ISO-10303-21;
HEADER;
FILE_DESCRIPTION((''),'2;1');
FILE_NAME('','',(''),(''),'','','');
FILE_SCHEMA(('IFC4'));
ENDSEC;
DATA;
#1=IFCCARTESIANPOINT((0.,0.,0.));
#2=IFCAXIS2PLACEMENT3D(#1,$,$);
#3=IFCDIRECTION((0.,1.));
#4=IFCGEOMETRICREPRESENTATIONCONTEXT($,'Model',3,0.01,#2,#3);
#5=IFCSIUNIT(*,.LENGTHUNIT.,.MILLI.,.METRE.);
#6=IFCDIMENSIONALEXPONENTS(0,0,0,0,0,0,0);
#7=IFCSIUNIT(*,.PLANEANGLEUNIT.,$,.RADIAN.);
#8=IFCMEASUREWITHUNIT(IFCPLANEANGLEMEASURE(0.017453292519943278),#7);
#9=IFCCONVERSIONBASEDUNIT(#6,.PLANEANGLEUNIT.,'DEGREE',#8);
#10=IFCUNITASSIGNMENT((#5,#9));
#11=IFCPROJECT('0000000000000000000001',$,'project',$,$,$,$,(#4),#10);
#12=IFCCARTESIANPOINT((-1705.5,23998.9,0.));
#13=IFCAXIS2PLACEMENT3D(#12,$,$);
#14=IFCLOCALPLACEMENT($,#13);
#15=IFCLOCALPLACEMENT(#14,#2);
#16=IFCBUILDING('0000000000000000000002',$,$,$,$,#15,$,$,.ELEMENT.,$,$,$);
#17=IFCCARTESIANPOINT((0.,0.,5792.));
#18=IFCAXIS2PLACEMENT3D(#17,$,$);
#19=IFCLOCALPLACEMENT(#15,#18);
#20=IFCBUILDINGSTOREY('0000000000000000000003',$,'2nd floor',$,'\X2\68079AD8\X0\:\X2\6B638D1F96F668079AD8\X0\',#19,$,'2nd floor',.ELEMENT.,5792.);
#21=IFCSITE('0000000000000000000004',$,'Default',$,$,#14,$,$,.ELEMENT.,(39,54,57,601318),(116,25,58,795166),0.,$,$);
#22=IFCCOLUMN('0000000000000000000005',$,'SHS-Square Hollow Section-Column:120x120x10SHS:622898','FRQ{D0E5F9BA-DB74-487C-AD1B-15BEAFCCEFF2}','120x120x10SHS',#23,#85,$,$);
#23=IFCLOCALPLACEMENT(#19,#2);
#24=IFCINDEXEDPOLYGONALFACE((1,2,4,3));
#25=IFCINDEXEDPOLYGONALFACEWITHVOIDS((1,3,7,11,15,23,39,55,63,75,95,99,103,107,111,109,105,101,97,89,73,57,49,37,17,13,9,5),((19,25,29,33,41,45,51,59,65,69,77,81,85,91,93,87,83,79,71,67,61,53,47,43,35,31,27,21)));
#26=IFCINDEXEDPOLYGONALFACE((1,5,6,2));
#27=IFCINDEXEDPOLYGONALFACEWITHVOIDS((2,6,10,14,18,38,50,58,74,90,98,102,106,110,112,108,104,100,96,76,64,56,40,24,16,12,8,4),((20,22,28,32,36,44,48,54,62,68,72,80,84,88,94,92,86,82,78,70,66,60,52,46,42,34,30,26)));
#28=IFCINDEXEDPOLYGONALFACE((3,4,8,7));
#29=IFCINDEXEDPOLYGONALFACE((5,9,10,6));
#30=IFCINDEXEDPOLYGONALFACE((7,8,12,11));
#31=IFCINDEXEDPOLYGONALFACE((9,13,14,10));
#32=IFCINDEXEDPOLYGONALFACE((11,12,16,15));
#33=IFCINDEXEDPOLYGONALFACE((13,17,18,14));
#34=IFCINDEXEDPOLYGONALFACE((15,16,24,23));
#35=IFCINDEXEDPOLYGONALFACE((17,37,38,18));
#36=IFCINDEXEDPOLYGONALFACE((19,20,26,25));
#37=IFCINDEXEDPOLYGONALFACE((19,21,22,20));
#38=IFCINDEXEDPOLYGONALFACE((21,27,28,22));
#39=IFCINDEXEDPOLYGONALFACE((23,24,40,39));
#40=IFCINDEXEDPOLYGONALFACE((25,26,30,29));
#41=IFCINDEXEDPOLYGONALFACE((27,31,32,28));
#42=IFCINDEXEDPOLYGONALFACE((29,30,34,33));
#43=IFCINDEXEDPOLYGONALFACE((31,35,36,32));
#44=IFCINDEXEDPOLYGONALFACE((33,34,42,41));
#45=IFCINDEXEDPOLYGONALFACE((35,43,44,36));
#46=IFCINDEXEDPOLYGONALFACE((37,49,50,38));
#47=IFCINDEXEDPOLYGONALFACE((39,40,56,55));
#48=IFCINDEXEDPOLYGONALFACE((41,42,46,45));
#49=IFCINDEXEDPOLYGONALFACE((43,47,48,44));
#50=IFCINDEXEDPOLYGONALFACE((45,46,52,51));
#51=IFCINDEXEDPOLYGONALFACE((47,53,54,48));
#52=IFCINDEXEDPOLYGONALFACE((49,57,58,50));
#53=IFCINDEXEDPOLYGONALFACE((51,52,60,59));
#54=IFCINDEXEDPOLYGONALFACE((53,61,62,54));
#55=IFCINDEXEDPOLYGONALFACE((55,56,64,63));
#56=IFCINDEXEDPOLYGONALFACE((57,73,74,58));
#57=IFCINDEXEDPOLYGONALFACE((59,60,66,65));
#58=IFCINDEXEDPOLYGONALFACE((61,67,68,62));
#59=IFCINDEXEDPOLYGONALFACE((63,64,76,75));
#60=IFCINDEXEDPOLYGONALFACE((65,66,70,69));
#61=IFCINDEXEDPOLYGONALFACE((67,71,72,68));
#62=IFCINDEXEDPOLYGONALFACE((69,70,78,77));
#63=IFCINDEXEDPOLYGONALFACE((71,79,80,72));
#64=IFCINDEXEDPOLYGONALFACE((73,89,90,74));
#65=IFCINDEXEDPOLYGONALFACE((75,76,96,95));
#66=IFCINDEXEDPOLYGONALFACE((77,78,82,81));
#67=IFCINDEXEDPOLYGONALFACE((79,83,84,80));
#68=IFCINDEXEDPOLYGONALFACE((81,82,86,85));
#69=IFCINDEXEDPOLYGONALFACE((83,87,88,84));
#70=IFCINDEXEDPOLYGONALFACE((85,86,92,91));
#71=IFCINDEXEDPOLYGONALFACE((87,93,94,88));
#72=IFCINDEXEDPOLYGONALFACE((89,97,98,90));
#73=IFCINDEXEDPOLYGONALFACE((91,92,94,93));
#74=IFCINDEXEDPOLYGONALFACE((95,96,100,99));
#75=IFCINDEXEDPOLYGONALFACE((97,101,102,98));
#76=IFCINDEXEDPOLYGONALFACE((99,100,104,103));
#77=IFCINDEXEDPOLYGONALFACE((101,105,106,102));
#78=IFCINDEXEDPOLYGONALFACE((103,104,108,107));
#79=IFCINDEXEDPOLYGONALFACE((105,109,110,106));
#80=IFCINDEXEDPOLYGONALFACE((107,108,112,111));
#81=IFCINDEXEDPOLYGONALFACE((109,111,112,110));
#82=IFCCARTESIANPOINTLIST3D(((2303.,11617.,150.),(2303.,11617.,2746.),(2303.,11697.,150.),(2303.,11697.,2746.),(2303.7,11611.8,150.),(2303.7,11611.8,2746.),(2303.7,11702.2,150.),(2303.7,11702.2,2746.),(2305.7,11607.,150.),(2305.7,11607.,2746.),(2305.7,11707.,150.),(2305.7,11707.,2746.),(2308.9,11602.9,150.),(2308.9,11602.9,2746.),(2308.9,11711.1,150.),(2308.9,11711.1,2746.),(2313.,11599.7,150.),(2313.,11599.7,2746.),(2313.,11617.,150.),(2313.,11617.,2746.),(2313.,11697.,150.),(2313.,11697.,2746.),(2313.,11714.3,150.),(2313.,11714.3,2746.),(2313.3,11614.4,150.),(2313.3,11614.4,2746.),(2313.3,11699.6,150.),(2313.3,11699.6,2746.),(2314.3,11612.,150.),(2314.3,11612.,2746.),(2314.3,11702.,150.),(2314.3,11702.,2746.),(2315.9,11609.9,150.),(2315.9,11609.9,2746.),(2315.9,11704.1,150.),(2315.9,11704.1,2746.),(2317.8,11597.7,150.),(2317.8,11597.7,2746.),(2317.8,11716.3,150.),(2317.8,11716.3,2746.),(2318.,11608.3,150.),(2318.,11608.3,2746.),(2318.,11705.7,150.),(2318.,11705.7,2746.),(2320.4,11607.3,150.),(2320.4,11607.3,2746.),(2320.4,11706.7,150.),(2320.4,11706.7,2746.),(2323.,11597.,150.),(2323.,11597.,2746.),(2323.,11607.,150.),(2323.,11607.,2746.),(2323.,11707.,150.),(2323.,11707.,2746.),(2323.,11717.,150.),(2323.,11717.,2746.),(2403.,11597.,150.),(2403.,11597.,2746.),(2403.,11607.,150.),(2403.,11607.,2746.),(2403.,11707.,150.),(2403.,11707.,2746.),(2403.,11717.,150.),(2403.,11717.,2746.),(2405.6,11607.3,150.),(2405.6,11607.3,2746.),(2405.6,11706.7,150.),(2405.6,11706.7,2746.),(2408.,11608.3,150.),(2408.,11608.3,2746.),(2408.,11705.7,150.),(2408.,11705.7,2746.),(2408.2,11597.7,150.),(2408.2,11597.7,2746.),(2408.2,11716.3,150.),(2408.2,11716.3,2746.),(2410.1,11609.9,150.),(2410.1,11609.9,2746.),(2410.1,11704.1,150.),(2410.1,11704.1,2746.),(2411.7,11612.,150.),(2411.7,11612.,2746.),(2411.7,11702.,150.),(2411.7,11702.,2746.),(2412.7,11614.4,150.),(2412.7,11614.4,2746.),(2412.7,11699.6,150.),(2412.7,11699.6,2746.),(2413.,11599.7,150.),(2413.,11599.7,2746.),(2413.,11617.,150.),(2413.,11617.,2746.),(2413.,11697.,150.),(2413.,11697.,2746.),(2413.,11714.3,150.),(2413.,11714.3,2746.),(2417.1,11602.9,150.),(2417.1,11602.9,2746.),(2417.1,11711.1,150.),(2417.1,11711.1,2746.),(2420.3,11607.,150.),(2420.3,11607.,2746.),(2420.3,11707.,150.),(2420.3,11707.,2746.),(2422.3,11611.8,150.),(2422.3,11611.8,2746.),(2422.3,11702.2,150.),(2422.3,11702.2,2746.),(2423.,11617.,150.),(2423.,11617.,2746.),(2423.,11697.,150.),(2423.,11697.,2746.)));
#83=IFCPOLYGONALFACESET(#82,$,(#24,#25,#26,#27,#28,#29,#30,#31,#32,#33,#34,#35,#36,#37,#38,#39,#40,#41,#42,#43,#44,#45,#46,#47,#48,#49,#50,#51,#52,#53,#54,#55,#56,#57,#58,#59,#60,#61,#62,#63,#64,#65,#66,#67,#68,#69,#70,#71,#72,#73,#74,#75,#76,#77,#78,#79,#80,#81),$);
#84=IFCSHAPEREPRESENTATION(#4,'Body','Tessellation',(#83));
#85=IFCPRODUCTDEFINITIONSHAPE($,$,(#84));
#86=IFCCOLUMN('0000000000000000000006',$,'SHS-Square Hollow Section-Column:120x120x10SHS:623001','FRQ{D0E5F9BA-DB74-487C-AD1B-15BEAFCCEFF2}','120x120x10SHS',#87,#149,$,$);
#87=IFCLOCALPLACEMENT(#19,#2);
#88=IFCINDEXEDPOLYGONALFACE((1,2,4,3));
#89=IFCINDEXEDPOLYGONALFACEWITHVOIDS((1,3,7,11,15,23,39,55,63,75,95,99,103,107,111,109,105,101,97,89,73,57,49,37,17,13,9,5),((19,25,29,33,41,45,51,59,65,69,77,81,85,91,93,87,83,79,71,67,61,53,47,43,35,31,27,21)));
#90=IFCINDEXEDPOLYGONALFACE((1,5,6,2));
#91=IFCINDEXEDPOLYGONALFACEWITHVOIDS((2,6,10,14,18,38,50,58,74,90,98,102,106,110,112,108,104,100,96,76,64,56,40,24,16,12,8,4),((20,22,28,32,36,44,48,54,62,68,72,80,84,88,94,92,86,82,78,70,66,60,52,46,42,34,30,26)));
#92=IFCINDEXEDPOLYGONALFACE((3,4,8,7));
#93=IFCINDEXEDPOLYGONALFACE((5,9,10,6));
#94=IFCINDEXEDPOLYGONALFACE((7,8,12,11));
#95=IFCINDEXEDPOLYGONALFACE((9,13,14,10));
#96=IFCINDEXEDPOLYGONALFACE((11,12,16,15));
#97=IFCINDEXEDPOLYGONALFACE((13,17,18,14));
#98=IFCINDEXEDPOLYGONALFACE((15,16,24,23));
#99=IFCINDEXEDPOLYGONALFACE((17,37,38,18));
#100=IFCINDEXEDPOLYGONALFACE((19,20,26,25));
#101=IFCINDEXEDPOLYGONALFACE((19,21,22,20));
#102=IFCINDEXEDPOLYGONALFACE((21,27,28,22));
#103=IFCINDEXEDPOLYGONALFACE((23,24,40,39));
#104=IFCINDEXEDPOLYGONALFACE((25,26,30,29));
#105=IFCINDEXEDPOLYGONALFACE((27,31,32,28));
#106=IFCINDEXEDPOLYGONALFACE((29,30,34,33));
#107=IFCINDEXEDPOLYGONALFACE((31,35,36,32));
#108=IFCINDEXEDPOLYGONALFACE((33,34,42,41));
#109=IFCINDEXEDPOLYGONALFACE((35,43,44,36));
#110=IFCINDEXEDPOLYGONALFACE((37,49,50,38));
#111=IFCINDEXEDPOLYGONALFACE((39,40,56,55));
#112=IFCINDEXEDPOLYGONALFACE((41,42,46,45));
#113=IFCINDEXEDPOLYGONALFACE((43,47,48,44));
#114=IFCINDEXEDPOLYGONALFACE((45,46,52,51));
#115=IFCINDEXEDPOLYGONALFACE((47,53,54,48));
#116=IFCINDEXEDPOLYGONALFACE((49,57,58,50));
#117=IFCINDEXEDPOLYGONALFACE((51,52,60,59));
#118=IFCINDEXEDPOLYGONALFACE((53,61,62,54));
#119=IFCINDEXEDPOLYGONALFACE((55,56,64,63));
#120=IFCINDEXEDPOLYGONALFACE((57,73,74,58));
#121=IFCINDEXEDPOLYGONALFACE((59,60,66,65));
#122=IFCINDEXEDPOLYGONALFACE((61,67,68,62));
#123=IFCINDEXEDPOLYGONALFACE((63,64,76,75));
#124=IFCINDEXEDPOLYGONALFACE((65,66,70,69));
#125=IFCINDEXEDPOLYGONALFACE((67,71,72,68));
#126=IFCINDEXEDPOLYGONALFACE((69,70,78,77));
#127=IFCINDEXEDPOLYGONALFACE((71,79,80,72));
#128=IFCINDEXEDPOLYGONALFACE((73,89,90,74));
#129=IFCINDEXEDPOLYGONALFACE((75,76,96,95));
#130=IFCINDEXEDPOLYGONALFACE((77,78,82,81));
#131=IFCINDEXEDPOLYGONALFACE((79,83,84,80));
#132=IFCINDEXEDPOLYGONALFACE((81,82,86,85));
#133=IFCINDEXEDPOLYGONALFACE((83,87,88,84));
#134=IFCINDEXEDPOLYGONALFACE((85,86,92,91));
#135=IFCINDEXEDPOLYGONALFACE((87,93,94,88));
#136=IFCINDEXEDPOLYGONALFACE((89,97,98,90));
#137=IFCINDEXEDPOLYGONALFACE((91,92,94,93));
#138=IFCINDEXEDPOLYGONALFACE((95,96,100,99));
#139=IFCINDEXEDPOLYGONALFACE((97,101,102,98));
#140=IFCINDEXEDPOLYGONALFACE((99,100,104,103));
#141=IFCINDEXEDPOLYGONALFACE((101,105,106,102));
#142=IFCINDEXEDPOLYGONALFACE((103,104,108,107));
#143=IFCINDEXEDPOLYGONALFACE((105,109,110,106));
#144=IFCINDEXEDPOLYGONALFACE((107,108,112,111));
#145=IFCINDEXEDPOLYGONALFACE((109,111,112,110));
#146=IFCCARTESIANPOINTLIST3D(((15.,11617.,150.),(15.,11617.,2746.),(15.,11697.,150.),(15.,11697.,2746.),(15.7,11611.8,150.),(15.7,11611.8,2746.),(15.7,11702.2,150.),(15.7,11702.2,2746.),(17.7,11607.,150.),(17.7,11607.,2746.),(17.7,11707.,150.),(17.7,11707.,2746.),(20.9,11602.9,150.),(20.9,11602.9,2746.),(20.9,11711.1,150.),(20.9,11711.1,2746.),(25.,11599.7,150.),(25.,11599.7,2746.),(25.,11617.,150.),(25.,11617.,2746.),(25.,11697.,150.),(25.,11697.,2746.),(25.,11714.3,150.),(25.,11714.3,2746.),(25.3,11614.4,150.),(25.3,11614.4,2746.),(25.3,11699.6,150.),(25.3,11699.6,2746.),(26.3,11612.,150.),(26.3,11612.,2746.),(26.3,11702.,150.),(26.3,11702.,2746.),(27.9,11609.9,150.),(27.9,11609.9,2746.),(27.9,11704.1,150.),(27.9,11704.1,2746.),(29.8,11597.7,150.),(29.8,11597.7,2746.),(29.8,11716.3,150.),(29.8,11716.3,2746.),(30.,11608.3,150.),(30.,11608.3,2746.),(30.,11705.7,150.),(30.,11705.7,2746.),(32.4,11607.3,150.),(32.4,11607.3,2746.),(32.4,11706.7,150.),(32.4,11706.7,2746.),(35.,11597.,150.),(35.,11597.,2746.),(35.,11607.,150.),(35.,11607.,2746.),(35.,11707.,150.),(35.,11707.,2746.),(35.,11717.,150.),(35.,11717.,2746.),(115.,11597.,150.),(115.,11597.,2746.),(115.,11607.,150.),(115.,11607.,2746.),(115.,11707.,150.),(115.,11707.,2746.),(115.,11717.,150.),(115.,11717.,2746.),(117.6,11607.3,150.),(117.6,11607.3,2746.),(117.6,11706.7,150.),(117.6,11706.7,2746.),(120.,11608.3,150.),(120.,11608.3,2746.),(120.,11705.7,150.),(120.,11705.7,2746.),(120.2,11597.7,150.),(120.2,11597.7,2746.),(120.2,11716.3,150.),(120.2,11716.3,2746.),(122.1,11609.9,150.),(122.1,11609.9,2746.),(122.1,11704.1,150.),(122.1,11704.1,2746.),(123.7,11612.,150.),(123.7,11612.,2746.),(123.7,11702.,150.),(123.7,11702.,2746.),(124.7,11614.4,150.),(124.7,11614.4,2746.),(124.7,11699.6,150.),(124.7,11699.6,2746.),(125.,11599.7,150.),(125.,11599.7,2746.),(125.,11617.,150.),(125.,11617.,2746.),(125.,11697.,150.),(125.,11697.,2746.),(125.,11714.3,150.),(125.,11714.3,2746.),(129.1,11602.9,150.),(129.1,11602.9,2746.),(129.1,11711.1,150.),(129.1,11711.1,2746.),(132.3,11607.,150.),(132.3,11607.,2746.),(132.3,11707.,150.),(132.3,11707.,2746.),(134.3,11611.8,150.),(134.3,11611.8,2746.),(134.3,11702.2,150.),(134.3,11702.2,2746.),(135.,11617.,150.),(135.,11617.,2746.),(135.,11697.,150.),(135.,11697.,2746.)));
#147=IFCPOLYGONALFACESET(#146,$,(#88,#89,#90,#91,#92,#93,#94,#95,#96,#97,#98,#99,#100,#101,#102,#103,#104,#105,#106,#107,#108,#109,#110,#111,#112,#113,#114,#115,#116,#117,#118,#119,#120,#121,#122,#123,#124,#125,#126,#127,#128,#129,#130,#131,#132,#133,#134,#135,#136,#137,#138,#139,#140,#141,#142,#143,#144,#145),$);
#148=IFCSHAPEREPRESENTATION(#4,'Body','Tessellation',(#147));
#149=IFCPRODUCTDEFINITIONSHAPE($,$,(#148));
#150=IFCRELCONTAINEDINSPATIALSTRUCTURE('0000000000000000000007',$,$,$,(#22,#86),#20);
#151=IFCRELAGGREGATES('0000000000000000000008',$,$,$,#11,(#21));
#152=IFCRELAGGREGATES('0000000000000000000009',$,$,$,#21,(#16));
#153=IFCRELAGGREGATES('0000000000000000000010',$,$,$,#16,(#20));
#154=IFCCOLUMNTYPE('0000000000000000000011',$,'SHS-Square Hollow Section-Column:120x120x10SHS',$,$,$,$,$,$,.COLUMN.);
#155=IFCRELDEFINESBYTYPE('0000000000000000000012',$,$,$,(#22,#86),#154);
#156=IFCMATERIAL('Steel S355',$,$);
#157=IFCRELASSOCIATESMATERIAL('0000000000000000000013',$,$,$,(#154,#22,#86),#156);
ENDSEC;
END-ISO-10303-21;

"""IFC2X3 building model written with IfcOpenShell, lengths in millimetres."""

from ifc_helpers import new_model, entity, si_unit, converted_unit, direction, frame, origin, origin_2d, place, context, project, spatial, hollow_rectangle, extrude, clip, halfspace, material, type_object, element, save


model = new_model("IFC2X3")

# Units and contexts
model_context = context("Model", 3, precision=0.01, world=origin(), true_north=direction((0.0, 1.0)))
ifc_project = project(units=[si_unit("LENGTHUNIT", "METRE", prefix="MILLI"), converted_unit("PLANEANGLEUNIT", "DEGREE", entity("IfcPlaneAngleMeasure", 0.017453292519943278), si_unit("PLANEANGLEUNIT", "RADIAN"), dimensions=[0, 0, 0, 0, 0, 0, 0])], contexts=[model_context])

# Site, building, storey
site_placement = place(None, frame((-1705.5, 23998.9, 0.0)))
site = spatial("IfcSite", under=ifc_project, at=site_placement, Name="Default", CompositionType="ELEMENT", RefLatitude=(39, 54, 57, 601318), RefLongitude=(116, 25, 58, 795166), RefElevation=0.0)
building_placement = place(site_placement, origin())
building = spatial("IfcBuilding", under=site, at=building_placement, CompositionType="ELEMENT")
storey_placement = place(building_placement, frame((0.0, 0.0, 5792.0)))
storey = spatial("IfcBuildingStorey", under=building, at=storey_placement, Name="2nd floor", ObjectType="标高:正负零标高", LongName="2nd floor", CompositionType="ELEMENT", Elevation=5792.0)

# Shared definitions
ifc_material_1 = material(Name="Steel S355")

# Columns
column_type_1 = type_object("IfcColumnType", Name="SHS-Square Hollow Section-Column:120x120x10SHS", PredefinedType="COLUMN", material=ifc_material_1)
column_1_placement = place(storey_placement, frame((2363.0, 11657.0, 2830.9), z_axis=(0.0, 0.0, 1.0), x_axis=(0.0, -1.0, 0.0)))
element("IfcColumn", 1, at=column_1_placement, inside=storey, type_object=column_type_1, material=ifc_material_1, Name="SHS-Square Hollow Section-Column:120x120x10SHS:622898", Description="FRQ{D0E5F9BA-DB74-487C-AD1B-15BEAFCCEFF2}", ObjectType="120x120x10SHS", context=model_context, shape_type="Clipping", body=[
    clip(clip(extrude(hollow_rectangle(XDim=120.0, YDim=120.0, WallThickness=10.0, InnerFilletRadius=10.0, OuterFilletRadius=20.0, at=origin_2d()), origin(), (0.0, 0.0, -1.0), 2765.7), halfspace(frame((11657.0, -2363.0, -84.9), z_axis=(0.0, 0.0, -1.0), x_axis=(0.0, -1.0, 0.0)), True)), halfspace(frame((11657.0, -2363.0, -2680.9), z_axis=(0.0, 0.0, 1.0), x_axis=(0.0, 1.0, 0.0)), True)),
])
column_2_placement = place(storey_placement, frame((75.0, 11657.0, 2830.9), z_axis=(0.0, 0.0, 1.0), x_axis=(0.0, -1.0, 0.0)))
element("IfcColumn", 2, at=column_2_placement, inside=storey, type_object=column_type_1, material=ifc_material_1, Name="SHS-Square Hollow Section-Column:120x120x10SHS:623001", Description="FRQ{D0E5F9BA-DB74-487C-AD1B-15BEAFCCEFF2}", ObjectType="120x120x10SHS", context=model_context, shape_type="Clipping", body=[
    clip(clip(extrude(hollow_rectangle(XDim=120.0, YDim=120.0, WallThickness=10.0, InnerFilletRadius=10.0, OuterFilletRadius=20.0, at=origin_2d()), origin(), (0.0, 0.0, -1.0), 2765.7), halfspace(frame((11657.0, -75.0, -84.9), z_axis=(0.0, 0.0, -1.0), x_axis=(0.0, -1.0, 0.0)), True)), halfspace(frame((11657.0, -75.0, -2680.9), z_axis=(0.0, 0.0, 1.0), x_axis=(0.0, 1.0, 0.0)), True)),
])

save(model, "model.ifc")
